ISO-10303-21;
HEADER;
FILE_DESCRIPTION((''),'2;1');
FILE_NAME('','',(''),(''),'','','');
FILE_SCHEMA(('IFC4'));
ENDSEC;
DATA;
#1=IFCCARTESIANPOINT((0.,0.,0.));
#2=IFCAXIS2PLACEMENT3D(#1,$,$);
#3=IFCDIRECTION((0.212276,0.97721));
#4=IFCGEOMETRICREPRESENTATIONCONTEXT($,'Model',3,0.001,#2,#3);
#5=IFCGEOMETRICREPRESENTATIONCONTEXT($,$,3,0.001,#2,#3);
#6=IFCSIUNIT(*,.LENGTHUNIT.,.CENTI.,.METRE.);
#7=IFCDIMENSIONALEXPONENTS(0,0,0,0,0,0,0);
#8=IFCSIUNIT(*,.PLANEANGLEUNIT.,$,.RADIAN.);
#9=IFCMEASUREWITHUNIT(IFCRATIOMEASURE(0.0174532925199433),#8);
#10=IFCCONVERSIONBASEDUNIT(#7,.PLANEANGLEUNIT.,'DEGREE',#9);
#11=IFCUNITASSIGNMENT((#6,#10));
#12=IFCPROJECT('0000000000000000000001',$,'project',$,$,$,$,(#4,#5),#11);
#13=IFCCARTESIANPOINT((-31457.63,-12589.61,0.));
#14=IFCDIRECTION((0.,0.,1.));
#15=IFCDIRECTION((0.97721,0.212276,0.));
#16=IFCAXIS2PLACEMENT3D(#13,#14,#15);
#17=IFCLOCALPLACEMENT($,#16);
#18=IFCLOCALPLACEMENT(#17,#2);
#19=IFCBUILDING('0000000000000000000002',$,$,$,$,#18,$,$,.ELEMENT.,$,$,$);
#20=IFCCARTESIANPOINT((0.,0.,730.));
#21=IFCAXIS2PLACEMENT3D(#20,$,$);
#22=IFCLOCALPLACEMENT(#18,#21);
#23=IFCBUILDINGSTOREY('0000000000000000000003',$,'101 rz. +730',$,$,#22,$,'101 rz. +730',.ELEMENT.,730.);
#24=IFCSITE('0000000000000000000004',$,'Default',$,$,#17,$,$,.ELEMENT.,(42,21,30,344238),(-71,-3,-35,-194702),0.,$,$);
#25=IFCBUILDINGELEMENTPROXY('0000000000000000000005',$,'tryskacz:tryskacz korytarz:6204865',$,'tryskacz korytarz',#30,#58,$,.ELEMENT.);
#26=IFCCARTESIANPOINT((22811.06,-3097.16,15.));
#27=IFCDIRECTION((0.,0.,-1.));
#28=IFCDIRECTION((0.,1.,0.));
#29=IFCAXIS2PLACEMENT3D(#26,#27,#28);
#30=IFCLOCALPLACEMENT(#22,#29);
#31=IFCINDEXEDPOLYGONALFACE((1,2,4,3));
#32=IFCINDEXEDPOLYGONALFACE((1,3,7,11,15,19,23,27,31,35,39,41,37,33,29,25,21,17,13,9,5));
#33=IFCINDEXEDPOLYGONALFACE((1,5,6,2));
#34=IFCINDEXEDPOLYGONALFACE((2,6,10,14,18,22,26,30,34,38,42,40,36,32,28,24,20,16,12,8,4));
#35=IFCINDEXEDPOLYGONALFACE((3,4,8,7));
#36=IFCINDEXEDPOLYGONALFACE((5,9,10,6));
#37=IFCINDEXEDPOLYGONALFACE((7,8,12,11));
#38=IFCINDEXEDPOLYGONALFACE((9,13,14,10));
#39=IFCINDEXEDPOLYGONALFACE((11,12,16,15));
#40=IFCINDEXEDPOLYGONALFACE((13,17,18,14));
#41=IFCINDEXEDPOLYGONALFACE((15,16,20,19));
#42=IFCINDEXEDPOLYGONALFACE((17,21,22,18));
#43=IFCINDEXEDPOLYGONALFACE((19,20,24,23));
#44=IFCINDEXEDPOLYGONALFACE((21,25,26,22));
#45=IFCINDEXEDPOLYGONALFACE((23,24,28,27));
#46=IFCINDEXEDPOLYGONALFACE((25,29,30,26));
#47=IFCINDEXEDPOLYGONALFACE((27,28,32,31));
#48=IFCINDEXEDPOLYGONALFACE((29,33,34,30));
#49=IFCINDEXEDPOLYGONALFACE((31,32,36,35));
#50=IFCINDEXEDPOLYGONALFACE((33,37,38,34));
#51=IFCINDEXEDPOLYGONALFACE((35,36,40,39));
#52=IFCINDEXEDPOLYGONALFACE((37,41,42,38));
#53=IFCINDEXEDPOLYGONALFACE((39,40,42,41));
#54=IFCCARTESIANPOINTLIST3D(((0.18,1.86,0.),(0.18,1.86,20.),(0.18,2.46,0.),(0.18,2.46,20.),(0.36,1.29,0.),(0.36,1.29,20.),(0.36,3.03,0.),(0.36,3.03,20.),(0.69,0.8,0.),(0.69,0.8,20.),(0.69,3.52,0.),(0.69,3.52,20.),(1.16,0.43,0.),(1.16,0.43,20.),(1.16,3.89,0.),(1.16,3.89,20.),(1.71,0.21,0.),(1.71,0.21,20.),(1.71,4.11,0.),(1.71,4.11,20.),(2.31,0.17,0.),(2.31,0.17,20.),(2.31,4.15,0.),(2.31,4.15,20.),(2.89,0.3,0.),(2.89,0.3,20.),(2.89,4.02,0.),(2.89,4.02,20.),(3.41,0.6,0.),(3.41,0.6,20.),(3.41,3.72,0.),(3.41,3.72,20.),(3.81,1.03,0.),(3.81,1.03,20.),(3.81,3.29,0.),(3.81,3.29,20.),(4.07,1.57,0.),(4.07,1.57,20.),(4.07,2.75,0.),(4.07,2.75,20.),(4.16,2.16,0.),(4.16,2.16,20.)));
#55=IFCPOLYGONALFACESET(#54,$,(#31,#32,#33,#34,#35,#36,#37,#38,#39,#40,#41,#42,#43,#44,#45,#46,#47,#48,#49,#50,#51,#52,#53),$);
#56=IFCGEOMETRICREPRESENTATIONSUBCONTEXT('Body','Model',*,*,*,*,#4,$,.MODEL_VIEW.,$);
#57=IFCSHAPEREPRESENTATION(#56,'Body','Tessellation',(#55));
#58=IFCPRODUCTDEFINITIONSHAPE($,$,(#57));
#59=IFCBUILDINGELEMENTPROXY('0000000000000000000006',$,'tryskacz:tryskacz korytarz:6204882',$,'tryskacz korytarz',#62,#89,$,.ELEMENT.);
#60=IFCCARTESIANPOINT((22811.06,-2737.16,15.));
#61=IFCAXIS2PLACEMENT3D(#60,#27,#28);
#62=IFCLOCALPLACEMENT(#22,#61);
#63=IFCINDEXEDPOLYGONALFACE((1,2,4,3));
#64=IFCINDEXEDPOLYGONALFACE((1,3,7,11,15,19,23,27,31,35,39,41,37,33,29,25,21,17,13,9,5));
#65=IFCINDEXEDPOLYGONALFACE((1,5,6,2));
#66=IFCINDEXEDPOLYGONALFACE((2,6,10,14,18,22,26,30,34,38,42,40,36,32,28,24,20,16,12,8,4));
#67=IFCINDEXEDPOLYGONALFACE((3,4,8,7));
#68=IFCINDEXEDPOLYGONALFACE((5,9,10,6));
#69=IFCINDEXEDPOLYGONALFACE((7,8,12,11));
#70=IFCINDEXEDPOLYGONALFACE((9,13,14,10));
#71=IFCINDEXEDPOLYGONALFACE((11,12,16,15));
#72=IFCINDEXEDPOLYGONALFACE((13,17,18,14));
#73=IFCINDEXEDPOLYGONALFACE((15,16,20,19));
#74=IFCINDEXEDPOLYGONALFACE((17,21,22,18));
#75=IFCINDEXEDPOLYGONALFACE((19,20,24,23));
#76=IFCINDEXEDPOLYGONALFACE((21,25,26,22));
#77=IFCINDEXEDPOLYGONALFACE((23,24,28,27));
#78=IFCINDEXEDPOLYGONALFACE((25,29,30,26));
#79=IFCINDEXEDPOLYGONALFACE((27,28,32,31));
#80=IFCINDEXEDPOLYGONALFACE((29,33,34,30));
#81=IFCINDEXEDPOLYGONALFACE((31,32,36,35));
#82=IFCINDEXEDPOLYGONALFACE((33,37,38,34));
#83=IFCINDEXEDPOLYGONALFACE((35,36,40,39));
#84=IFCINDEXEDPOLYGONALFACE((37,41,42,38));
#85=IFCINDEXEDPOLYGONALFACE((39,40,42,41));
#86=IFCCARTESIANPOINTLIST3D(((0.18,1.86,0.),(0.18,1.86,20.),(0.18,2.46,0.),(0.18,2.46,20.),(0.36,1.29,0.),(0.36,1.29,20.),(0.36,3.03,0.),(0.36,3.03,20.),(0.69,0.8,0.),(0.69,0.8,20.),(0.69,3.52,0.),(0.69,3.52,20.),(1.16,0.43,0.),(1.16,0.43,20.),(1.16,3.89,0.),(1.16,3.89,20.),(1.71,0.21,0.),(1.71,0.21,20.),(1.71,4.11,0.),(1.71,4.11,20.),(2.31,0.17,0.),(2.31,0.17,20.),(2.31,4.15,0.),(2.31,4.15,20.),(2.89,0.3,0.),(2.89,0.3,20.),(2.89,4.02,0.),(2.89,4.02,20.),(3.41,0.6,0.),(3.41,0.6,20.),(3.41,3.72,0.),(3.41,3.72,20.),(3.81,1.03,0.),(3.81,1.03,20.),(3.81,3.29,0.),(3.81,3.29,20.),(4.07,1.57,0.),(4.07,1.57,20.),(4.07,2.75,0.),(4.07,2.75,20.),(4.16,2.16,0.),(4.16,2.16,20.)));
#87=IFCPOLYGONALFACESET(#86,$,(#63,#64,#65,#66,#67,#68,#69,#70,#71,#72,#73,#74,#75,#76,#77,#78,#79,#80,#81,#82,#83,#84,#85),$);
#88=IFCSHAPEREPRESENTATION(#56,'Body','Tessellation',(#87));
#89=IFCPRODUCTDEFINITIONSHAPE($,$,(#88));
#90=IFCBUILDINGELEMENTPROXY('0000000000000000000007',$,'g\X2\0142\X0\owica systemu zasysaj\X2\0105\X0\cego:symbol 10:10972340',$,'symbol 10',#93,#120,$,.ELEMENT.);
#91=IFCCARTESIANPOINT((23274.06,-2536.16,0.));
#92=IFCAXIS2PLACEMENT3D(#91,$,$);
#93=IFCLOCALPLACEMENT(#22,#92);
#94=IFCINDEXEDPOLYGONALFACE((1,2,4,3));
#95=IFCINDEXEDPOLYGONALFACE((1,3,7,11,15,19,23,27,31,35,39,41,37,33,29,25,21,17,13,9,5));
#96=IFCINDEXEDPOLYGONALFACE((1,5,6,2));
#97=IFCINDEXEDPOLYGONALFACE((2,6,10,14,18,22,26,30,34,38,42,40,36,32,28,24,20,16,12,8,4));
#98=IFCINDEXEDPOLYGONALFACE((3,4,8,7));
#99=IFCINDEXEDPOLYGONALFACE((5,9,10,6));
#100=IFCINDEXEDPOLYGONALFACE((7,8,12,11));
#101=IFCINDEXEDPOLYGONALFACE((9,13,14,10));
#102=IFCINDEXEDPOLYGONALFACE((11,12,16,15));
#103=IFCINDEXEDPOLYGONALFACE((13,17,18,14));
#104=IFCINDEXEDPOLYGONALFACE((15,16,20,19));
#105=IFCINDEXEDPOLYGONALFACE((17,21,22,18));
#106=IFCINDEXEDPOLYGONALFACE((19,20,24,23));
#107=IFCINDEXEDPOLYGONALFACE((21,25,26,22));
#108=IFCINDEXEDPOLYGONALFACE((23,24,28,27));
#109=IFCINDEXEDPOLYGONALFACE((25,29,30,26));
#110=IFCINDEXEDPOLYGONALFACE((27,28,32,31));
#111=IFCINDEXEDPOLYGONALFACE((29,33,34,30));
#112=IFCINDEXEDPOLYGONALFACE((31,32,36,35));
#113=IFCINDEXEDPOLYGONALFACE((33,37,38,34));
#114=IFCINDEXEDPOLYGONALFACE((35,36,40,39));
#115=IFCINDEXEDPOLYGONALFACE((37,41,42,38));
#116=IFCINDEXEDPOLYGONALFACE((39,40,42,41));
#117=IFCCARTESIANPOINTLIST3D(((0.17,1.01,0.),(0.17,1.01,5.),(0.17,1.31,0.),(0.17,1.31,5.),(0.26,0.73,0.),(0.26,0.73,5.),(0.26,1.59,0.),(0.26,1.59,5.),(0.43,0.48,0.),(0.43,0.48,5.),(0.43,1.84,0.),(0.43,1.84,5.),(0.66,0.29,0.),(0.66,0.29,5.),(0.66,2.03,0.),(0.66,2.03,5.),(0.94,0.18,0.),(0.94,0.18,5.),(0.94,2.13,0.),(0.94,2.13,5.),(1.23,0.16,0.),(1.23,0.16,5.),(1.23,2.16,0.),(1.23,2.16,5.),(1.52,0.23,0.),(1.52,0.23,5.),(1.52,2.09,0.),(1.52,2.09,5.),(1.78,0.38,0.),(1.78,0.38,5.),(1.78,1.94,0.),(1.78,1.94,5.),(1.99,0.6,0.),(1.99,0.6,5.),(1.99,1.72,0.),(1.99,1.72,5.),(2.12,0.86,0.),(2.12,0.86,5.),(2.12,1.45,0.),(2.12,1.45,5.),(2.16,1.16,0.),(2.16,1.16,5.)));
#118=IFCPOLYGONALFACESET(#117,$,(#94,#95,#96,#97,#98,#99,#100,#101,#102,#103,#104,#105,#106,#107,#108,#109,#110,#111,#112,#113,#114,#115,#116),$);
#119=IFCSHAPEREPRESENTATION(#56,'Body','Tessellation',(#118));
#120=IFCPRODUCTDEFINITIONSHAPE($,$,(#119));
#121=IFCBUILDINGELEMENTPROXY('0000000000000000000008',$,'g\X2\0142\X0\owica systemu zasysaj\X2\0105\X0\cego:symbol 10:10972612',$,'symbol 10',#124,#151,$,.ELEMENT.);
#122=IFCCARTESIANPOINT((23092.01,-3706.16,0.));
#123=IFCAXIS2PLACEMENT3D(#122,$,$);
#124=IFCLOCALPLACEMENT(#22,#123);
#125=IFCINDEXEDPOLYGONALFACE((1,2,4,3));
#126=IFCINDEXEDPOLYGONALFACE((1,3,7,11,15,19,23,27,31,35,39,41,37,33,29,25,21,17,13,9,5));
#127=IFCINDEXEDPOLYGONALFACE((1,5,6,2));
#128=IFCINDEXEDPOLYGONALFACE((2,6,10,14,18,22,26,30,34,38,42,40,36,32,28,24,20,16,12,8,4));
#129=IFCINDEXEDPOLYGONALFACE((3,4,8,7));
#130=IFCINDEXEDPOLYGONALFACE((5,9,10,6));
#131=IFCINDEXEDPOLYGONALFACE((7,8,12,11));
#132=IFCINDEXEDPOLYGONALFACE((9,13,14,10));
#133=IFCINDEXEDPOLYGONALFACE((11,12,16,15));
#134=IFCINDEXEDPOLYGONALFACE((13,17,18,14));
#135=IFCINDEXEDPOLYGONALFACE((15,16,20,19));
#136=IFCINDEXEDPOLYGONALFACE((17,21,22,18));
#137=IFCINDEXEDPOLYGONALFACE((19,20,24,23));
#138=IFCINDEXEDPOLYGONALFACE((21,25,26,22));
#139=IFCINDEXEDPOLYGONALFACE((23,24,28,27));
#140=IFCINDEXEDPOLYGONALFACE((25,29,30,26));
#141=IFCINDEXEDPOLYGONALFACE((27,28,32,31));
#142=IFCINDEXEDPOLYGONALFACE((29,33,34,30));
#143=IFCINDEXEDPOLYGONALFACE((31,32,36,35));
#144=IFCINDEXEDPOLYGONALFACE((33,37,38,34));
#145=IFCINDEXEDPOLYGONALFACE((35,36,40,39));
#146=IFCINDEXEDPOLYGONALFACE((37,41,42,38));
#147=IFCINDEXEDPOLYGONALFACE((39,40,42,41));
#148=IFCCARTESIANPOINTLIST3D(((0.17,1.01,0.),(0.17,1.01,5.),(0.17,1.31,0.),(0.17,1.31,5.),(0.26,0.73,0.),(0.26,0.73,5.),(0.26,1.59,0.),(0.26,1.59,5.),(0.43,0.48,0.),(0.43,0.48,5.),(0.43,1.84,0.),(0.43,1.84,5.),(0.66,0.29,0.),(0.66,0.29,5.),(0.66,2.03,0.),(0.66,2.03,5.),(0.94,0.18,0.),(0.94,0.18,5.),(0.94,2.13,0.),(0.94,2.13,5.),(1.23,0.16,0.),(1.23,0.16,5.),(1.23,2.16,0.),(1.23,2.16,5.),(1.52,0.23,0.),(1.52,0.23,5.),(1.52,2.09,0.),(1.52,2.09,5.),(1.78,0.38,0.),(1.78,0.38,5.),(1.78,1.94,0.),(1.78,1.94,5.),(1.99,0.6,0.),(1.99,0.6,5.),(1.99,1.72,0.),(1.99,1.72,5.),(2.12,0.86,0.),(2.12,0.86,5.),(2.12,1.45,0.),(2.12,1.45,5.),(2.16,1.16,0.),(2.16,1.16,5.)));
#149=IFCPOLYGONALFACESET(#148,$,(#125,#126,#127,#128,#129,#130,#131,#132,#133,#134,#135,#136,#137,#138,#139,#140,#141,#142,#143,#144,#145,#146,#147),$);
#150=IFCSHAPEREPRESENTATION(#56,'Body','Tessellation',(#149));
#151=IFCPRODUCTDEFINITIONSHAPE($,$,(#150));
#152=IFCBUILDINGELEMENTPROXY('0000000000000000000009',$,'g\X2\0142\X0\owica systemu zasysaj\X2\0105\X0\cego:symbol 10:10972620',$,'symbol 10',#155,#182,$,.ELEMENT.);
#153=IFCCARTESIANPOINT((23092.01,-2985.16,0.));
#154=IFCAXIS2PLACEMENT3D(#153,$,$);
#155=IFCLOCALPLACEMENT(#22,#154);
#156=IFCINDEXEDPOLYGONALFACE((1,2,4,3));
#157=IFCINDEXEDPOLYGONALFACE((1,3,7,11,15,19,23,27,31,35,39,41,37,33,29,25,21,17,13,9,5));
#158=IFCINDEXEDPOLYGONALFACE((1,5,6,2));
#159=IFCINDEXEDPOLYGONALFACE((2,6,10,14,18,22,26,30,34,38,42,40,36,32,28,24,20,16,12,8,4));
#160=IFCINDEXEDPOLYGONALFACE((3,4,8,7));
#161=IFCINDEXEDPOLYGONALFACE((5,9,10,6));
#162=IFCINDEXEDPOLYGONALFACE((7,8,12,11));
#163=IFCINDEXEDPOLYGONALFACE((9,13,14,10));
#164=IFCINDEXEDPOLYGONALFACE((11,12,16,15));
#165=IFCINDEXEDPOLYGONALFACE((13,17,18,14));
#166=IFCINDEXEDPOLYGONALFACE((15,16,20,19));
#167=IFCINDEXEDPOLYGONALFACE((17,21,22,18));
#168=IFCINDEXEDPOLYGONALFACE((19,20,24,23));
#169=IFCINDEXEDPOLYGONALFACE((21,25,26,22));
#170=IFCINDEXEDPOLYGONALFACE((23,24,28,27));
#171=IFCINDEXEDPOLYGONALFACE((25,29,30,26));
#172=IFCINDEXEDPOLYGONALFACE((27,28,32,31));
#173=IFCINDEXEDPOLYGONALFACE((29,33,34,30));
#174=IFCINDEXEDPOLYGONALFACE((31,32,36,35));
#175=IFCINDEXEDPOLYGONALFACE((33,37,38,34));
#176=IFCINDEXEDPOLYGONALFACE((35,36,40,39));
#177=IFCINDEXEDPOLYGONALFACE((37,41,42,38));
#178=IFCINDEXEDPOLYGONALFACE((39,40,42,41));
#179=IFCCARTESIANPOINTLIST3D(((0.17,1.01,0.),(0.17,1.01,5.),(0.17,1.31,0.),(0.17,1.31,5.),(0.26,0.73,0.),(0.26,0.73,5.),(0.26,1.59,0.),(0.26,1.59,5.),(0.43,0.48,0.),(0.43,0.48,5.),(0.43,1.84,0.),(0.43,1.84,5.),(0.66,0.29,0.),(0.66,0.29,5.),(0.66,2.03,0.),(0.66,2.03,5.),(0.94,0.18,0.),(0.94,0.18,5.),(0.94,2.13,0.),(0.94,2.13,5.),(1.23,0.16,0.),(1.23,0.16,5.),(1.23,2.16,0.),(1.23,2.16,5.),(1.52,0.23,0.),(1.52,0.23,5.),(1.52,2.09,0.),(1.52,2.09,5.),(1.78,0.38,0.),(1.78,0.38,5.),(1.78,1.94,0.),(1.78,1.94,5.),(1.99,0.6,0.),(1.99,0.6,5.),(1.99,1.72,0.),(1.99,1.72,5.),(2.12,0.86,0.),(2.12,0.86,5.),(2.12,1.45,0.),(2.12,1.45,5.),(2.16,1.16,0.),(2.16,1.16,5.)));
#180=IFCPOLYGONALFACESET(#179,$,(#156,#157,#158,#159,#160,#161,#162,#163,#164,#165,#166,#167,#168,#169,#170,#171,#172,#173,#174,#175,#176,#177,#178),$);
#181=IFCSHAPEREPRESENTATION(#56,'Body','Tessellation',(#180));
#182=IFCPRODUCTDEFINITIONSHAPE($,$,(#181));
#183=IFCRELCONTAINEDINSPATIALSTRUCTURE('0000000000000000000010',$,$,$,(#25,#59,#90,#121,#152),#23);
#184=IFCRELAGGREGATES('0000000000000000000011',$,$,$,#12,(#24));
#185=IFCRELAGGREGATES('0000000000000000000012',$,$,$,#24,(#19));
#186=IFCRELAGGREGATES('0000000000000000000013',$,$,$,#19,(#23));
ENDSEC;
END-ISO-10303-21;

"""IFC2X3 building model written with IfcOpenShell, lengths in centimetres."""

from ifc_helpers import new_model, entity, si_unit, converted_unit, direction, frame, frame_2d, origin, place, context, subcontext, project, spatial, circle, extrude, source, transform, mapped, element, save


model = new_model("IFC2X3")

# Units and contexts
model_context = context("Model", 3, precision=0.001, world=origin(), true_north=direction((0.212276, 0.97721)))
context_of_model = context(None, 3, precision=0.001, world=origin(), true_north=direction((0.212276, 0.97721)))
body_context = subcontext(model_context, "Body", "Model", "MODEL_VIEW")
ifc_project = project(units=[si_unit("LENGTHUNIT", "METRE", prefix="CENTI"), converted_unit("PLANEANGLEUNIT", "DEGREE", entity("IfcRatioMeasure", 0.0174532925199433), si_unit("PLANEANGLEUNIT", "RADIAN"), dimensions=[0, 0, 0, 0, 0, 0, 0])], contexts=[model_context, context_of_model])

# Site, building, storey
site_placement = place(None, frame((-31457.63, -12589.61, 0.0), z_axis=(0.0, 0.0, 1.0), x_axis=(0.97721, 0.212276, 0.0)))
site = spatial("IfcSite", under=ifc_project, at=site_placement, Name="Default", CompositionType="ELEMENT", RefLatitude=(42, 21, 30, 344238), RefLongitude=(-71, -3, -35, -194702), RefElevation=0.0)
building_placement = place(site_placement, origin())
building = spatial("IfcBuilding", under=site, at=building_placement, CompositionType="ELEMENT")
storey_placement = place(building_placement, frame((0.0, 0.0, 730.0)))
storey = spatial("IfcBuildingStorey", under=building, at=storey_placement, Name="101 rz. +730", LongName="101 rz. +730", CompositionType="ELEMENT", Elevation=730.0)

# Building element proxies
shared_shape_1 = source(origin(), body_context, "Body", "SweptSolid", [
    extrude(circle(Radius=2.0, at=frame_2d((0.0, 0.0), x_axis=(1.0, 0.0))), frame((2.16, 2.16, 0.0)), (0.0, 0.0, 1.0), 20.0),
])
for number, where, z_axis, x_axis, name in (
    (1, (22811.06, -3097.16, 15.0), (0.0, 0.0, -1.0), (0.0, 1.0, 0.0), "tryskacz:tryskacz korytarz:6204865"),
    (2, (22811.06, -2737.16, 15.0), (0.0, 0.0, -1.0), (0.0, 1.0, 0.0), "tryskacz:tryskacz korytarz:6204882"),
):
    element("IfcBuildingElementProxy", number, at=place(storey_placement, frame(where, z_axis=z_axis, x_axis=x_axis)), inside=storey, Name=name, ObjectType="tryskacz korytarz", CompositionType="ELEMENT", context=body_context, shape_type="MappedRepresentation", body=[
        mapped(shared_shape_1, transform((0.0, 0.0, 0.0), scale=1.0)),
    ])
shared_shape_2 = source(origin(), body_context, "Body", "SweptSolid", [
    extrude(circle(Radius=1.0, at=frame_2d((0.0, 0.0), x_axis=(1.0, 0.0))), frame((1.16, 1.16, 0.0)), (0.0, 0.0, 1.0), 5.0),
])
for number, where, name in (
    (3, (23274.06, -2536.16, 0.0), "głowica systemu zasysającego:symbol 10:10972340"),
    (4, (23092.01, -3706.16, 0.0), "głowica systemu zasysającego:symbol 10:10972612"),
    (5, (23092.01, -2985.16, 0.0), "głowica systemu zasysającego:symbol 10:10972620"),
):
    element("IfcBuildingElementProxy", number, at=place(storey_placement, frame(where)), inside=storey, Name=name, ObjectType="symbol 10", CompositionType="ELEMENT", context=body_context, shape_type="MappedRepresentation", body=[
        mapped(shared_shape_2, transform((0.0, 0.0, 0.0), scale=1.0)),
    ])

save(model, "model.ifc")
